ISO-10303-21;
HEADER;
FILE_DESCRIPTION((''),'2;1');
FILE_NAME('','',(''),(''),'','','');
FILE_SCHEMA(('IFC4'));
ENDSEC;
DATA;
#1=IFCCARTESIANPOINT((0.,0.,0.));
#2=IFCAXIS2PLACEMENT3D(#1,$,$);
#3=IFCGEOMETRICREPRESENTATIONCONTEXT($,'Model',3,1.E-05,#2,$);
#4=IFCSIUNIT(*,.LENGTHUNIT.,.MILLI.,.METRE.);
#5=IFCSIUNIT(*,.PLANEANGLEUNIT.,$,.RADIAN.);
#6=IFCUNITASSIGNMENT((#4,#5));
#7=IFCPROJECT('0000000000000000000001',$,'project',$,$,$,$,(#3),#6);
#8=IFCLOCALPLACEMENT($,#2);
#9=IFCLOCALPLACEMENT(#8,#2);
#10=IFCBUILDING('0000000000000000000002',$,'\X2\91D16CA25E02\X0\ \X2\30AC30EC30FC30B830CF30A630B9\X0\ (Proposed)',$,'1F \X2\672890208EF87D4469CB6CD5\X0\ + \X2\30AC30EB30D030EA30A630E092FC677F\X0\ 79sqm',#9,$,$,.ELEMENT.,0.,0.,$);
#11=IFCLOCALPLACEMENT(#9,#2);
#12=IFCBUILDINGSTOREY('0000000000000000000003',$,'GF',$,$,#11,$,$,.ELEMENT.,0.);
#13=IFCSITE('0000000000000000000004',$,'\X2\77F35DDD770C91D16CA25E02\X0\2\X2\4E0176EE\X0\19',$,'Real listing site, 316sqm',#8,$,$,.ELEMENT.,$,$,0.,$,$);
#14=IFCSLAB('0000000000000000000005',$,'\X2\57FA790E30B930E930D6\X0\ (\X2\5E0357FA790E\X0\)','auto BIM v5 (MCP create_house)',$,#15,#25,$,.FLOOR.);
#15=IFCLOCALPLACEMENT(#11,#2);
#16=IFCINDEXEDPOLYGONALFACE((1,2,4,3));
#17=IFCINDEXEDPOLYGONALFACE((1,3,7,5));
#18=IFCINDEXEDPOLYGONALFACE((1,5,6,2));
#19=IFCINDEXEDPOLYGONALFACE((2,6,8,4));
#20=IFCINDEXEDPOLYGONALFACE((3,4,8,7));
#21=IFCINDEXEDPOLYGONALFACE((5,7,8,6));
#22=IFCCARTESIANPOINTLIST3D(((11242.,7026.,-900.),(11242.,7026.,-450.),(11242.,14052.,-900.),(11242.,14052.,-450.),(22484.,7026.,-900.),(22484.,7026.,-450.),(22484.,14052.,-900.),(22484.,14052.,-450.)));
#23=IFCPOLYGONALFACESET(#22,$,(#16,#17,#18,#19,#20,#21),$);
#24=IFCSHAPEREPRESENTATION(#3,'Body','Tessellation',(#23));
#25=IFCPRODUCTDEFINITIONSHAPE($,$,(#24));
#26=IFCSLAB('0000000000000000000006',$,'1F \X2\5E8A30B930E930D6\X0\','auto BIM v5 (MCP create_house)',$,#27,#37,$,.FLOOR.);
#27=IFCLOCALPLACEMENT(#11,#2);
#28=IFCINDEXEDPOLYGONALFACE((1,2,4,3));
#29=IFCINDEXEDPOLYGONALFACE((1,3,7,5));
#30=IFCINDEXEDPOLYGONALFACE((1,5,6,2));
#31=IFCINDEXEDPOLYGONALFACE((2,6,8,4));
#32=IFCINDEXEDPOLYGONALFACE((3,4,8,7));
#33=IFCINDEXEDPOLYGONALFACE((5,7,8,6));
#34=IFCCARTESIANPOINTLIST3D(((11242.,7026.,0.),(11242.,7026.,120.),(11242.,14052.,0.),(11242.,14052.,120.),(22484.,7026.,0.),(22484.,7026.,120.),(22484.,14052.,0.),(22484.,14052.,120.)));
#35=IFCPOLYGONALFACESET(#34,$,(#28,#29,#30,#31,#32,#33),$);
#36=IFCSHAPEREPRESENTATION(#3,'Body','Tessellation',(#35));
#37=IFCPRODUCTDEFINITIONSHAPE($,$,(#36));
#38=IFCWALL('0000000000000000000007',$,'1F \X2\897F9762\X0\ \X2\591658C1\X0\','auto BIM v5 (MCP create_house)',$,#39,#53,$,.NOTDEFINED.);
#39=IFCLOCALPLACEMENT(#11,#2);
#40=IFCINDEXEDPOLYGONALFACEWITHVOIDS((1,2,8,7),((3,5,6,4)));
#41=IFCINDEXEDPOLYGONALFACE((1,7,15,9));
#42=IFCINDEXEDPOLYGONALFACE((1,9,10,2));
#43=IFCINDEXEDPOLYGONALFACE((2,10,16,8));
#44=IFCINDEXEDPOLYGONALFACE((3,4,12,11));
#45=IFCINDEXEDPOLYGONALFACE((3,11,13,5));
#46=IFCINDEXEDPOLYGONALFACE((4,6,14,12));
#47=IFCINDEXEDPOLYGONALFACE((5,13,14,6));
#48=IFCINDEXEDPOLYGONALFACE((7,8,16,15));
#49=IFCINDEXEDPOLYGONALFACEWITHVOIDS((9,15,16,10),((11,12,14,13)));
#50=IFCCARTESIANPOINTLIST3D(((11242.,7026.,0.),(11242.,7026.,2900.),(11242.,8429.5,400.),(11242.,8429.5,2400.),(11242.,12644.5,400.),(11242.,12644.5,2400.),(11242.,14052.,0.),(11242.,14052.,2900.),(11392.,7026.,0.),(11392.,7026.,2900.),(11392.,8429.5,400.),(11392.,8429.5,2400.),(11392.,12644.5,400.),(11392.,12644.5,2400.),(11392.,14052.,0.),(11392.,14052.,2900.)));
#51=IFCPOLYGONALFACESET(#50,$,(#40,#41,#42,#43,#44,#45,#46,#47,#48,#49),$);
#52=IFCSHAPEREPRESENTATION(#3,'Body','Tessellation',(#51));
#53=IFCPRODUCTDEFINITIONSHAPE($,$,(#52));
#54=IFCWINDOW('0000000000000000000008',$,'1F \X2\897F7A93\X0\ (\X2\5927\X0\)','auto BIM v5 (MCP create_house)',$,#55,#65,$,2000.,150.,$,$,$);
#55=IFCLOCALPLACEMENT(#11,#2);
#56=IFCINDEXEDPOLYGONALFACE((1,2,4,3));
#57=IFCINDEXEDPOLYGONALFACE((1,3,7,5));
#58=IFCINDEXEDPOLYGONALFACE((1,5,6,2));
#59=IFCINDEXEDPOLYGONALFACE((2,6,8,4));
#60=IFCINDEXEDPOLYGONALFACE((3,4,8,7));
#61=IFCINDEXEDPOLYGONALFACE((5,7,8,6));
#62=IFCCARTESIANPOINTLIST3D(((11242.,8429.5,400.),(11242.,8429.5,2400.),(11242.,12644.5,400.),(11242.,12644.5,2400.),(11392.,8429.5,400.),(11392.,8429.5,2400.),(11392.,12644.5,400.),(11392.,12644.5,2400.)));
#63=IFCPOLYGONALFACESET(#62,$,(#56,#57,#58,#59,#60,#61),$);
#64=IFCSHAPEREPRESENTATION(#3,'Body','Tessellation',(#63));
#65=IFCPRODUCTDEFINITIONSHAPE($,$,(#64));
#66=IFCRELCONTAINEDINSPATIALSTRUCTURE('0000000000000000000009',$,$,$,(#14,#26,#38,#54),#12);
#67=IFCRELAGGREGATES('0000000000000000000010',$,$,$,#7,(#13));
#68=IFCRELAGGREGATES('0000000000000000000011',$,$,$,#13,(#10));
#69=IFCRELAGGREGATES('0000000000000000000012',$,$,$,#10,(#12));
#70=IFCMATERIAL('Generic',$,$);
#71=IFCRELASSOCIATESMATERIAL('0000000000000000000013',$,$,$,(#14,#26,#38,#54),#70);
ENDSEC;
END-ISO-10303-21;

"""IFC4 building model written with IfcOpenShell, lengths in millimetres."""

from ifc_helpers import new_model, si_unit, frame, frame_2d, origin, place, context, project, spatial, rectangle, extrude, material, element, fill, save


model = new_model("IFC4")

# Units and contexts
model_context = context("Model", 3, precision=1e-05, world=origin())
ifc_project = project(units=[si_unit("LENGTHUNIT", "METRE", prefix="MILLI"), si_unit("PLANEANGLEUNIT", "RADIAN")], contexts=[model_context])

# Site, building, storey
site_placement = place(None, origin())
site = spatial("IfcSite", under=ifc_project, at=site_placement, Name="石川県金沢市2丁目19", ObjectType="Real listing site, 316sqm", CompositionType="ELEMENT", RefElevation=0.0)
building_placement = place(site_placement, origin())
building = spatial("IfcBuilding", under=site, at=building_placement, Name="金沢市 ガレージハウス (Proposed)", ObjectType="1F 木造軸組構法 + ガルバリウム鋼板 79sqm", CompositionType="ELEMENT", ElevationOfRefHeight=0.0, ElevationOfTerrain=0.0)
storey_placement = place(building_placement, origin())
storey = spatial("IfcBuildingStorey", under=building, at=storey_placement, Name="GF", CompositionType="ELEMENT", Elevation=0.0)

# Slabs
ifc_material = material(Name="Generic")
slab_1_placement = place(storey_placement, frame((5621.0, 3513.0, -450.0)))
element("IfcSlab", 1, at=slab_1_placement, inside=storey, material=ifc_material, Name="基礎スラブ (布基礎)", Description="auto BIM v5 (MCP create_house)", PredefinedType="FLOOR", context=model_context, shape_type="SweptSolid", body=[
    extrude(rectangle(XDim=11242.0, YDim=7026.0, at=frame_2d((5621.0, 3513.0))), frame((5621.0, 3513.0, -450.0)), (0.0, 0.0, 1.0), 450.0),
])
slab_2_placement = place(storey_placement, frame((5621.0, 3513.0, 0.0)))
element("IfcSlab", 2, at=slab_2_placement, inside=storey, material=ifc_material, Name="1F 床スラブ", Description="auto BIM v5 (MCP create_house)", PredefinedType="FLOOR", context=model_context, shape_type="SweptSolid", body=[
    extrude(rectangle(XDim=11242.0, YDim=7026.0, at=frame_2d((5621.0, 3513.0))), frame((5621.0, 3513.0, 0.0)), (0.0, 0.0, 1.0), 120.0),
])

# Wall, opening, window
wall_1_placement = place(storey_placement, frame((5621.0, 3513.0, 0.0)))
wall_1 = element("IfcWall", 3, at=wall_1_placement, inside=storey, material=ifc_material, Name="1F 西面 外壁", Description="auto BIM v5 (MCP create_house)", PredefinedType="NOTDEFINED", context=model_context, shape_type="SweptSolid", body=[
    extrude(rectangle(XDim=150.0, YDim=7026.0, at=frame_2d((75.0, 3513.0))), frame((5621.0, 3513.0, 0.0)), (0.0, 0.0, 1.0), 2900.0),
])
opening_1_placement = place(storey_placement, frame((5621.0, 4215.0, 200.0)))
opening_1 = element("IfcOpeningElement", 4, at=opening_1_placement, cuts=wall_1, PredefinedType="NOTDEFINED", context=model_context, shape_type="SweptSolid", body=[
    extrude(rectangle(XDim=150.0, YDim=4215.0, at=frame_2d((75.0, 2107.0))), frame((5621.0, 4215.0, 200.0)), (0.0, 0.0, 1.0), 2000.0),
])
window_1_placement = place(storey_placement, frame((5621.0, 4215.0, 200.0)))
window_1 = element("IfcWindow", 5, at=window_1_placement, inside=storey, material=ifc_material, Name="1F 西窓 (大)", Description="auto BIM v5 (MCP create_house)", OverallHeight=2000.0, OverallWidth=150.0, context=model_context, shape_type="SweptSolid", body=[
    extrude(rectangle(XDim=150.0, YDim=4215.0, at=frame_2d((75.0, 2107.0))), frame((5621.0, 4215.0, 200.0)), (0.0, 0.0, 1.0), 2000.0),
])
fill(opening_1, window_1)

save(model, "model.ifc")
